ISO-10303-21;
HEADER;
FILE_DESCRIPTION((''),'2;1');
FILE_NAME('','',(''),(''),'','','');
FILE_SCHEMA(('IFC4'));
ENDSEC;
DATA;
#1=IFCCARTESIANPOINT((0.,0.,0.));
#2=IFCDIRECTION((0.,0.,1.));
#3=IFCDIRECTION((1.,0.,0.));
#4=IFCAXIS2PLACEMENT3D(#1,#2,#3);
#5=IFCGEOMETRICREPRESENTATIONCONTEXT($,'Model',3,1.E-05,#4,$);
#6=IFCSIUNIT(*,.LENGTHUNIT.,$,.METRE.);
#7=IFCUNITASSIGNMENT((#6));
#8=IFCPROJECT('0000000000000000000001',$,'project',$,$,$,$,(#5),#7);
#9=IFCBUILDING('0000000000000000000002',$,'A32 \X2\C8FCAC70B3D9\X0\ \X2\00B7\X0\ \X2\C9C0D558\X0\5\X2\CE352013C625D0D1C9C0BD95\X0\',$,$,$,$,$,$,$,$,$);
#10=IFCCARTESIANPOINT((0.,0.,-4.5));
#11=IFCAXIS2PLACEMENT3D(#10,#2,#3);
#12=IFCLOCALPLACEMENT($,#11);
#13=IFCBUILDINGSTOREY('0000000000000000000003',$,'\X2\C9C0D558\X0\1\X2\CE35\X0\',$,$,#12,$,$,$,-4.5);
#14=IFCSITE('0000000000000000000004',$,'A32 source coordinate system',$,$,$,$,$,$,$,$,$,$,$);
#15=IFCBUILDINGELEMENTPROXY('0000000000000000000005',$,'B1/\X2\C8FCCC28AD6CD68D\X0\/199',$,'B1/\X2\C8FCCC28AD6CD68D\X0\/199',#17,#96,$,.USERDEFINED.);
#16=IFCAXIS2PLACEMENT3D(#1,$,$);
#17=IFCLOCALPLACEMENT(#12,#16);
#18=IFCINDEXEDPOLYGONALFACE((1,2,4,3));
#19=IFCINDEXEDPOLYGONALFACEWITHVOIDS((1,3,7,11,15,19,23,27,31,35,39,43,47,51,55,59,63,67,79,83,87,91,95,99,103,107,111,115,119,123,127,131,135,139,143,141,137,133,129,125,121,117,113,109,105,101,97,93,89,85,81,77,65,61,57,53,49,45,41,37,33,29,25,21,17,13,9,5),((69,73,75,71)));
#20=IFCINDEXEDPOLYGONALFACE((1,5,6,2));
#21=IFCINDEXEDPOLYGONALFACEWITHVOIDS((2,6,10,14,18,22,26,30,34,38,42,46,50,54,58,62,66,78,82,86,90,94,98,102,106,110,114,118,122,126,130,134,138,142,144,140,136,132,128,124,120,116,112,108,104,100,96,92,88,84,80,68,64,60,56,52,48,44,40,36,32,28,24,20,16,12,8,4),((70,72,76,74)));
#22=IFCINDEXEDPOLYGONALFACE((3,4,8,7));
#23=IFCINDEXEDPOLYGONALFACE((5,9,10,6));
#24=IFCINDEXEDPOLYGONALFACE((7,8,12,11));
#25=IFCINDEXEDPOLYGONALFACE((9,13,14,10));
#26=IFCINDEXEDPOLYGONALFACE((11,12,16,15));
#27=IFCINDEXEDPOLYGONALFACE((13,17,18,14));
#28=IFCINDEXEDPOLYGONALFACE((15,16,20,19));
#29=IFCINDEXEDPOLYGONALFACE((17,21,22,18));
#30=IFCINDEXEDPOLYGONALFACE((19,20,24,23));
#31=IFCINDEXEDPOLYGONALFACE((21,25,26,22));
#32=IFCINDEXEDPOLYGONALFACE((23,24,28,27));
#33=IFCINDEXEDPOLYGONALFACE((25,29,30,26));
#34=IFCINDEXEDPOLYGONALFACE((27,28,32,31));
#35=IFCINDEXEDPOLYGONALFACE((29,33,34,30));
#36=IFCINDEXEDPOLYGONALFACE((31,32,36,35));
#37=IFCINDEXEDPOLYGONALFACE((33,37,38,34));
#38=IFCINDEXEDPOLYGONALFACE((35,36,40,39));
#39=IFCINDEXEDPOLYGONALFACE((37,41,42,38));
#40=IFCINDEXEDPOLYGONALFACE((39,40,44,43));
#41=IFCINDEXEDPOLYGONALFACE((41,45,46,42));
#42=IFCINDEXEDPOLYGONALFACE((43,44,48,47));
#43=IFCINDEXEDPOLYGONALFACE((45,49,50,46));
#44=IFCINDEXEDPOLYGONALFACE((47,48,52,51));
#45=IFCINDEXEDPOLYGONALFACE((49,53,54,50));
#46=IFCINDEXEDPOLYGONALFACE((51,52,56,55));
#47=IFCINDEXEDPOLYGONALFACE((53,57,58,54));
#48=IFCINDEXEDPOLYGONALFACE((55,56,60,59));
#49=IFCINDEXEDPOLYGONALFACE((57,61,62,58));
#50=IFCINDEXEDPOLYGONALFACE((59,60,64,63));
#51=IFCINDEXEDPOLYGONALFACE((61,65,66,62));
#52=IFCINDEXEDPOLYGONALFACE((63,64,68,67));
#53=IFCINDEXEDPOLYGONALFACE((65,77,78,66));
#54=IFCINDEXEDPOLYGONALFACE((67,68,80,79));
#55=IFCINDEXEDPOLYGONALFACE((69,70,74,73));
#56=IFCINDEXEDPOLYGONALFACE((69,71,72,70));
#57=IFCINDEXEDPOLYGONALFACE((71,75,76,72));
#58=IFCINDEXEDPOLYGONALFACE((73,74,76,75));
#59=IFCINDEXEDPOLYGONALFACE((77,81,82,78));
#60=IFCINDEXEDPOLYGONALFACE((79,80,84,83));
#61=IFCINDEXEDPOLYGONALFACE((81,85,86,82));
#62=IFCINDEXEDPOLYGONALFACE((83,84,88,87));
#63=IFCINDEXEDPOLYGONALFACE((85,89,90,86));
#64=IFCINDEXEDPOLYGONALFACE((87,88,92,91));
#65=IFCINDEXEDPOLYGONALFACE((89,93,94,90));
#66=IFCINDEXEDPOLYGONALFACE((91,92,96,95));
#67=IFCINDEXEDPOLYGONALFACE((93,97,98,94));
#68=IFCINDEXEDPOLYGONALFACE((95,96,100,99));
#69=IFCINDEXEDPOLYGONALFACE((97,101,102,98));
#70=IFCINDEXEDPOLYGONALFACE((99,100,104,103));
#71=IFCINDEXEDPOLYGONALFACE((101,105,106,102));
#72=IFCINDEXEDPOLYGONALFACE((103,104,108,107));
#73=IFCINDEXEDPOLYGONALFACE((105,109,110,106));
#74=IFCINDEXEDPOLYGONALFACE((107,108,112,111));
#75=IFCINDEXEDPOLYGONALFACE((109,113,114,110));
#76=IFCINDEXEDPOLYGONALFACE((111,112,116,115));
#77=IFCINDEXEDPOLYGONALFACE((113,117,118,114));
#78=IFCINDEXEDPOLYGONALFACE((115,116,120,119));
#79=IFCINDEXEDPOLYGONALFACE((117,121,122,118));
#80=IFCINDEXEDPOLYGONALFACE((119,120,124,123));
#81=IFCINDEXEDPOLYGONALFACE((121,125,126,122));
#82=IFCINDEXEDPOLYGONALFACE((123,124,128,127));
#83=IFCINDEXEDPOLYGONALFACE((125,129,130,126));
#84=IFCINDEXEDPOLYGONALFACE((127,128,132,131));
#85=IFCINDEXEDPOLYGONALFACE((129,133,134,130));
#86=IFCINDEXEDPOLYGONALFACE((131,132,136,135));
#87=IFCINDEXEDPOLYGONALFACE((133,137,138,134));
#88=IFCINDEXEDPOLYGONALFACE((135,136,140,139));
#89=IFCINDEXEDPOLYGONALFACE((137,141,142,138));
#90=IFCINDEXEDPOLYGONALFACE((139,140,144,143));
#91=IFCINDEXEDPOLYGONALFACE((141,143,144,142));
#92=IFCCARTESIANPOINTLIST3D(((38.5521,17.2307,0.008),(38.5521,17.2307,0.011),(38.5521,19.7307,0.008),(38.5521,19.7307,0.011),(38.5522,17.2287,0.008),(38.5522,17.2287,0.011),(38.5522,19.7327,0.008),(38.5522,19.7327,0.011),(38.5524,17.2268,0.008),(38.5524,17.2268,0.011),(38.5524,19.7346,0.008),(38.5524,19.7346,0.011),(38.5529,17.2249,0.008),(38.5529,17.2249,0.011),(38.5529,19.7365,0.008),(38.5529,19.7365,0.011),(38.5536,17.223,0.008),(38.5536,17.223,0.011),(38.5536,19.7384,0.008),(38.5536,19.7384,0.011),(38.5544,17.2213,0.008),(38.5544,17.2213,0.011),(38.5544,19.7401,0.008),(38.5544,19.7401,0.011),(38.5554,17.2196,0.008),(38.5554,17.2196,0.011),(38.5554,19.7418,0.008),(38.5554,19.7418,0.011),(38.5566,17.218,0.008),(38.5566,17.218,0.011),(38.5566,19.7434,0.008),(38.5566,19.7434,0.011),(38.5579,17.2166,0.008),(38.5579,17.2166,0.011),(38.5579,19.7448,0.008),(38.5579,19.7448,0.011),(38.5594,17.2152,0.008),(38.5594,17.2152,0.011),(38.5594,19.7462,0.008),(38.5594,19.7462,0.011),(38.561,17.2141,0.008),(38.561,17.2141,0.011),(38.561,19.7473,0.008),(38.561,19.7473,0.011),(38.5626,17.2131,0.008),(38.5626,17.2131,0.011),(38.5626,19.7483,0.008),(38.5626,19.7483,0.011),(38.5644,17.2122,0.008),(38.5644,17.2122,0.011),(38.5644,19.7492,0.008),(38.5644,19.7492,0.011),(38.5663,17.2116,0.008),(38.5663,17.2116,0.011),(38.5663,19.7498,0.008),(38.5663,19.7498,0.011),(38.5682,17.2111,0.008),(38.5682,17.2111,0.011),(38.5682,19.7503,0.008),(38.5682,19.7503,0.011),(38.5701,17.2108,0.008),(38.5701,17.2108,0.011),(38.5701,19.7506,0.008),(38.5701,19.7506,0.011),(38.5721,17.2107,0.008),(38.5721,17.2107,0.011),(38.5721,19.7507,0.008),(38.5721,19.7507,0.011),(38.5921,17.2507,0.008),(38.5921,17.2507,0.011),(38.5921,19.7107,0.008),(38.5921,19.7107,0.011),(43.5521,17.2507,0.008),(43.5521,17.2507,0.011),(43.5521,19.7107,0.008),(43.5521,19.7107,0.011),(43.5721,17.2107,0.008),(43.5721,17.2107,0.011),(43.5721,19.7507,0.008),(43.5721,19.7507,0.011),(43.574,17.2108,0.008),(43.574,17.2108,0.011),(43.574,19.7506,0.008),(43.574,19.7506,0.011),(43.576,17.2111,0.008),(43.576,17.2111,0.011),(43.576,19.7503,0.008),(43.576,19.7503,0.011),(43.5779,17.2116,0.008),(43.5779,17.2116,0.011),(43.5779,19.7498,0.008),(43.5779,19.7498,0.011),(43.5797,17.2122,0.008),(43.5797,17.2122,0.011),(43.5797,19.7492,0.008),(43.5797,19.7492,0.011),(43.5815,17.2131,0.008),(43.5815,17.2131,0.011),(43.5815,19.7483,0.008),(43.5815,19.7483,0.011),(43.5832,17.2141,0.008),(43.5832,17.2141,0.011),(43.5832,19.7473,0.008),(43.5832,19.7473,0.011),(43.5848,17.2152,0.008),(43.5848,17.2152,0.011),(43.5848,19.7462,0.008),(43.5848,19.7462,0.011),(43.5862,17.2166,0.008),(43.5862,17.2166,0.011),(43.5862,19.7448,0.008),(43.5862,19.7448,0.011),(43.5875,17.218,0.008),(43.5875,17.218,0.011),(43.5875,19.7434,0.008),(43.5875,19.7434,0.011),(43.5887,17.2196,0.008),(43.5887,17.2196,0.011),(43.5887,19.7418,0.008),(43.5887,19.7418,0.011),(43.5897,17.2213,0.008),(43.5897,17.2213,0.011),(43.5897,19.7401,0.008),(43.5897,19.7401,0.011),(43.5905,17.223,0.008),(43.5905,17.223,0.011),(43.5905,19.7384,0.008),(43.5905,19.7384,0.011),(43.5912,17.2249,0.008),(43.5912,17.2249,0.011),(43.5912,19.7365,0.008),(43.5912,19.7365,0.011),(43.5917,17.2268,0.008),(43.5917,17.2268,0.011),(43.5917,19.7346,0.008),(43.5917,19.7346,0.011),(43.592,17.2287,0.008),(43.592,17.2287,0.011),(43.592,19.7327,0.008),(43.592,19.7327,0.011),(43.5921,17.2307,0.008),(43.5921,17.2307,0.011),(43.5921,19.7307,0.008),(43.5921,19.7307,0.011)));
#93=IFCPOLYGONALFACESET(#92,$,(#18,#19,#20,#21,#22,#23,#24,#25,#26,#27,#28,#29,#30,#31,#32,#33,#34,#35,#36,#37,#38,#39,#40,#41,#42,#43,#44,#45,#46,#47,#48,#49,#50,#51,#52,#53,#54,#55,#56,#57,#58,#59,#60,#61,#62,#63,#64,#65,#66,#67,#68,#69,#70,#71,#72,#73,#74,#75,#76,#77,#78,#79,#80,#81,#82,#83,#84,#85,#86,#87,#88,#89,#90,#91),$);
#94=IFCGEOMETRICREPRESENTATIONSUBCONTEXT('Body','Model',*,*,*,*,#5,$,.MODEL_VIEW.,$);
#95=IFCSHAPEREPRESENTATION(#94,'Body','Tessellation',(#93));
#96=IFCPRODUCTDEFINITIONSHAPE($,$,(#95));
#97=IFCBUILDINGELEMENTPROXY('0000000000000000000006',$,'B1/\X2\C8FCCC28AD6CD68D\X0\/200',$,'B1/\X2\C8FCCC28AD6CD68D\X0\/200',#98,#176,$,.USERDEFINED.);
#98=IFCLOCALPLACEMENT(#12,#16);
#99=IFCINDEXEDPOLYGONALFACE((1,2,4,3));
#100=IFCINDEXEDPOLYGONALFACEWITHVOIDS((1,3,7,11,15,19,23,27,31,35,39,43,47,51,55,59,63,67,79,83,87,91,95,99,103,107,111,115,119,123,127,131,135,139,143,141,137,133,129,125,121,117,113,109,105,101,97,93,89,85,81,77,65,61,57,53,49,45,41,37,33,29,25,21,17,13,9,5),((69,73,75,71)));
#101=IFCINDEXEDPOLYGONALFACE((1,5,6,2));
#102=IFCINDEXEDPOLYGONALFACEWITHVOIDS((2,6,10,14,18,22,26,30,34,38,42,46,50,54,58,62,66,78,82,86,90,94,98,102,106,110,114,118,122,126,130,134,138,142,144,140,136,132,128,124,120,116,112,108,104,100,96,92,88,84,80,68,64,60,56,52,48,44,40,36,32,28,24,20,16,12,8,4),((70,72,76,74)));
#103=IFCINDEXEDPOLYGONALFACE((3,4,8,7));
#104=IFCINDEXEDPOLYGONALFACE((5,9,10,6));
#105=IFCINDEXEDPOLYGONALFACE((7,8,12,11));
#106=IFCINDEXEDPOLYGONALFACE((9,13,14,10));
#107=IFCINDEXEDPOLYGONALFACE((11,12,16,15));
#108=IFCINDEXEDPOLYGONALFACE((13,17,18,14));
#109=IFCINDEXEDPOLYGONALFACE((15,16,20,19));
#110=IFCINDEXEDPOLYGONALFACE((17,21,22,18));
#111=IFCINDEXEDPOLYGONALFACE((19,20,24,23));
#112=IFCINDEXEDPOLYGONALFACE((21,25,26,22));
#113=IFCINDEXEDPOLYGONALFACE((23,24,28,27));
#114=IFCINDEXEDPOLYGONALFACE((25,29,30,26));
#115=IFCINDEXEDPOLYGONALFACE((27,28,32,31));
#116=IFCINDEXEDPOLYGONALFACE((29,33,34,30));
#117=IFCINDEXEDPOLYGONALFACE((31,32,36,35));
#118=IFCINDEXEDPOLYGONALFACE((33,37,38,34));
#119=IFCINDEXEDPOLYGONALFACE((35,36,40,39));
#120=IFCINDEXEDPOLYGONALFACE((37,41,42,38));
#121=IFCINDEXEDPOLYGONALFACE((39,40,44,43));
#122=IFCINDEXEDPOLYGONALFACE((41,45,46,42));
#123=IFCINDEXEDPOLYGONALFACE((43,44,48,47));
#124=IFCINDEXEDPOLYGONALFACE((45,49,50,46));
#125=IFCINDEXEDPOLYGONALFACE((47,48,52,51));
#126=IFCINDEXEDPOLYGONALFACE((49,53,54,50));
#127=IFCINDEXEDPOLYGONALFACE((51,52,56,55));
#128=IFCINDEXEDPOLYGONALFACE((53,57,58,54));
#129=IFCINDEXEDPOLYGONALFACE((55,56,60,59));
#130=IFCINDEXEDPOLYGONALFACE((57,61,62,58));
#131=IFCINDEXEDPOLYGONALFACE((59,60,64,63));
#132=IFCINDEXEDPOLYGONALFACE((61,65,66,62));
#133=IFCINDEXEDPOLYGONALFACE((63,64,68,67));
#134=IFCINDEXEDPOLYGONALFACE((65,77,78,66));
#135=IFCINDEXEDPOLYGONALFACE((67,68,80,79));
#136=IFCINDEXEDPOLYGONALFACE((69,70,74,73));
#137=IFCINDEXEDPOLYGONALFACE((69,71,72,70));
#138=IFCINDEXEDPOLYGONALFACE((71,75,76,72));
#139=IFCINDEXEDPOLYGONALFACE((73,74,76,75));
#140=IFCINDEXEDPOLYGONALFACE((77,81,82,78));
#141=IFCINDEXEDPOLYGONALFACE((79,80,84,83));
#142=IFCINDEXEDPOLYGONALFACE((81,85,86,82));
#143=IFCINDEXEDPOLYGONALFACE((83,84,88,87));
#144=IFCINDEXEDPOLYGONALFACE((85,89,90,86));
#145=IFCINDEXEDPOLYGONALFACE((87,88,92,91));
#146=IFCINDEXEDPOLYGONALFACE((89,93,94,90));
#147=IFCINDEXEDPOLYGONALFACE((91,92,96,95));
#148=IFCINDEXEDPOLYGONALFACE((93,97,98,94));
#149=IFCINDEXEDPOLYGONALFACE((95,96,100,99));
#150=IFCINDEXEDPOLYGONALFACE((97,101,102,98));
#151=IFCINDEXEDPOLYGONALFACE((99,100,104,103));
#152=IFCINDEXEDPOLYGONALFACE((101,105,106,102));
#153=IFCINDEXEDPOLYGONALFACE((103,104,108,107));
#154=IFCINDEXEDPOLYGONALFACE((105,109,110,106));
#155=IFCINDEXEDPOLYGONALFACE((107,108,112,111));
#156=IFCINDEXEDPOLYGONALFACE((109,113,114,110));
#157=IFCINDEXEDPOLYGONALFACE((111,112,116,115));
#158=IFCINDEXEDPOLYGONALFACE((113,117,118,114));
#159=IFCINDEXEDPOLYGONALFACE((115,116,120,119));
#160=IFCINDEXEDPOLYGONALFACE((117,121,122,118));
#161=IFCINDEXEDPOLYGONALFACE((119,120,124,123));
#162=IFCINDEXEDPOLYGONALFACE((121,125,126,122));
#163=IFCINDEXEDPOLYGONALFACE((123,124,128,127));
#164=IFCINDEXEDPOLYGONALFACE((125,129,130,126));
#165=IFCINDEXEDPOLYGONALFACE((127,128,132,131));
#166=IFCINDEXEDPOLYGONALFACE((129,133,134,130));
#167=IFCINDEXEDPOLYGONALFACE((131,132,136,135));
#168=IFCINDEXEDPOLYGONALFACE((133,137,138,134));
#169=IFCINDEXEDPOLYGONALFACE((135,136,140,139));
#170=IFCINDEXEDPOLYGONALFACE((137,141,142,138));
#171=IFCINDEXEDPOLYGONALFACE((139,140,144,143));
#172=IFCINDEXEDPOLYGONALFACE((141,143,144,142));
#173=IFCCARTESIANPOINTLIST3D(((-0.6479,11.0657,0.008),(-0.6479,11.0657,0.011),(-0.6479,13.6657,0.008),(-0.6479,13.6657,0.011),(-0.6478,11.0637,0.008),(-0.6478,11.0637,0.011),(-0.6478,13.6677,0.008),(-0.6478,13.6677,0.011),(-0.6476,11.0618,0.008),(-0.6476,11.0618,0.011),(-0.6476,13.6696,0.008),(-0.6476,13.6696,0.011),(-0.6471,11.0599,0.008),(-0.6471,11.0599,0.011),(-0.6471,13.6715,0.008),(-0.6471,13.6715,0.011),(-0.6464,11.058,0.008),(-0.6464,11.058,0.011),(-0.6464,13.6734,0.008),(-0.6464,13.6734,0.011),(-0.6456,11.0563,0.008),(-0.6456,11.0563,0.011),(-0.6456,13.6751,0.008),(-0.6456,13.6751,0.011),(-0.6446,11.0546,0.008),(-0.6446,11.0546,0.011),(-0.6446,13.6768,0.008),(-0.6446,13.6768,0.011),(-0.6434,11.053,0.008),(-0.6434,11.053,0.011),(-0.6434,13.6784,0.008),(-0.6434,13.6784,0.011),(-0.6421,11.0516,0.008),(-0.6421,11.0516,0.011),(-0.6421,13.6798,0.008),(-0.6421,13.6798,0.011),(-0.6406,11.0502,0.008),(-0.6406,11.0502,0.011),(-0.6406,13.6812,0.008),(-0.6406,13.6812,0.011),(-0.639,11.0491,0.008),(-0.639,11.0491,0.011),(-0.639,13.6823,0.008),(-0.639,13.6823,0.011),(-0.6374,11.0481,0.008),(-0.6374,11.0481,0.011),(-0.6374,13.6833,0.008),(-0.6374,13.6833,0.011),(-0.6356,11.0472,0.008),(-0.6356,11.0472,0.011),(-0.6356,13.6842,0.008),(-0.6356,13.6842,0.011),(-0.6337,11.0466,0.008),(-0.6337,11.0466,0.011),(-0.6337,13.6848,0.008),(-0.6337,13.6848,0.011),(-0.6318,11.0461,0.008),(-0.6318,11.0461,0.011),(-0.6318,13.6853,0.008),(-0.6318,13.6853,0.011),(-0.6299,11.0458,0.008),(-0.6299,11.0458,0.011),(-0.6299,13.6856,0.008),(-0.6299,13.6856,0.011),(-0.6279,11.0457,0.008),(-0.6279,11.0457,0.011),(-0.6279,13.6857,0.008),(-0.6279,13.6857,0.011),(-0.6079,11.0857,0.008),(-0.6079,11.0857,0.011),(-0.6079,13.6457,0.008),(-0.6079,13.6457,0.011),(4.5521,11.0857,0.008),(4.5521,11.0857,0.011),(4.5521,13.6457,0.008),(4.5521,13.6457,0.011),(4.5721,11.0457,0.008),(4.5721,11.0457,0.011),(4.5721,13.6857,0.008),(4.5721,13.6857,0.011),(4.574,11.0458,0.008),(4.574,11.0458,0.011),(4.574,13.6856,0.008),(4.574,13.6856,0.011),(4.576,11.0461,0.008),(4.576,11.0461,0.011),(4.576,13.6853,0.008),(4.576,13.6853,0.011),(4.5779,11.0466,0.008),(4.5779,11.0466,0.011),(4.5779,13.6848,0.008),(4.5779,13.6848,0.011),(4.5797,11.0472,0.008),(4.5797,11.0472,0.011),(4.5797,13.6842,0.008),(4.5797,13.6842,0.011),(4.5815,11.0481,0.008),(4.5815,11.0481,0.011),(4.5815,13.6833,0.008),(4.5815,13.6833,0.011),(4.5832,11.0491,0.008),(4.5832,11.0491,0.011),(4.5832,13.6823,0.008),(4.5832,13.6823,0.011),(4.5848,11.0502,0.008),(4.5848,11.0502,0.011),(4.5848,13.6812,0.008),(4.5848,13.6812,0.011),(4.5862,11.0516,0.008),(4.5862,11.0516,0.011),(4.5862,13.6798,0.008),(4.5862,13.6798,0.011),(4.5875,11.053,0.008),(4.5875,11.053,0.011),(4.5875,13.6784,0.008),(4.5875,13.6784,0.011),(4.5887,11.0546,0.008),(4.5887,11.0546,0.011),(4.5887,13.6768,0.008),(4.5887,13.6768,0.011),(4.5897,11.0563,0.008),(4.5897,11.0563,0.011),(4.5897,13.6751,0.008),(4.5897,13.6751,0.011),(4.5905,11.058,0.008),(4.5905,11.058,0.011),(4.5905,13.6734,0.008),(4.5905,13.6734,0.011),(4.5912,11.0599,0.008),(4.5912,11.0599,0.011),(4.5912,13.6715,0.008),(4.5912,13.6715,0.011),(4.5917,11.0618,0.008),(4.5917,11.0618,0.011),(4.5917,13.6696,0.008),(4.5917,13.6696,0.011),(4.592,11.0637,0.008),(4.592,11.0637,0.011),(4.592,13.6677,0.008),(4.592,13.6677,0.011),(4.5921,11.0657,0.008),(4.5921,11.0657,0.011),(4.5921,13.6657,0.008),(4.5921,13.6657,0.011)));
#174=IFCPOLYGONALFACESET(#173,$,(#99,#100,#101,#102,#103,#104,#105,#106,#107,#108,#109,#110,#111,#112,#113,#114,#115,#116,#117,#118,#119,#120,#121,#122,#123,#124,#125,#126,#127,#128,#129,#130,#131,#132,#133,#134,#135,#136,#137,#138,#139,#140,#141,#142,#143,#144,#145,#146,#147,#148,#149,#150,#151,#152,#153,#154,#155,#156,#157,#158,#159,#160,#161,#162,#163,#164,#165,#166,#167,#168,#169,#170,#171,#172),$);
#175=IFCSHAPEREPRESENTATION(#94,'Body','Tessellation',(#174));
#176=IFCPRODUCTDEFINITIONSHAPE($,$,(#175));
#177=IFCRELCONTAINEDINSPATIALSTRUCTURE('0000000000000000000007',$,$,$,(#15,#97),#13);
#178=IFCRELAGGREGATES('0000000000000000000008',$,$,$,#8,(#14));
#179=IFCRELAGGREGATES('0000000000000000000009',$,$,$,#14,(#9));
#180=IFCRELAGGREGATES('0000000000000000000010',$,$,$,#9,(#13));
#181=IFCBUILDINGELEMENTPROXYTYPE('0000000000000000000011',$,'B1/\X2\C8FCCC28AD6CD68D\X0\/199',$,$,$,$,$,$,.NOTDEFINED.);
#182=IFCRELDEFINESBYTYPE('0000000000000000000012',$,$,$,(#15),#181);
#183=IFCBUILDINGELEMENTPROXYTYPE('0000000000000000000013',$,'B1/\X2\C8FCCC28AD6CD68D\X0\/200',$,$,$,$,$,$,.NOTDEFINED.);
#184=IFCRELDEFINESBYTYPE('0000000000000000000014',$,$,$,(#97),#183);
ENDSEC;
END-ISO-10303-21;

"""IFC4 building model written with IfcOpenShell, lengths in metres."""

from ifc_helpers import new_model, si_unit, frame, origin, origin_with_axes, place, context, subcontext, project, spatial, polyline, outline, extrude, source, transform, mapped, type_object, type_shapes, element, save


model = new_model("IFC4")

# Units and contexts
model_context = context("Model", 3, precision=1e-05, world=origin_with_axes())
body_context = subcontext(model_context, "Body", "Model", "MODEL_VIEW")
ifc_project = project(units=[si_unit("LENGTHUNIT", "METRE")], contexts=[model_context])

# Site, building, storey
site = spatial("IfcSite", under=ifc_project, Name="A32 source coordinate system")
building = spatial("IfcBuilding", under=site, Name="A32 주거동 · 지하5층–옥탑지붕")
storey_placement = place(None, frame((0.0, 0.0, -4.5), z_axis=(0.0, 0.0, 1.0), x_axis=(1.0, 0.0, 0.0)))
storey = spatial("IfcBuildingStorey", under=building, at=storey_placement, Name="지하1층", Elevation=-4.5)

# Building element proxies
building_element_proxy_type_1 = type_object("IfcBuildingElementProxyType", Name="B1/주차구획/199", PredefinedType="NOTDEFINED")
shared_shape_1 = source(origin(), body_context, "Body", "SweptSolid", [
    extrude(outline(polyline([(43.5721, 19.7507), (43.574, 19.7506), (43.576, 19.7503), (43.5779, 19.7498), (43.5797, 19.7492), (43.5815, 19.7483), (43.5832, 19.7473), (43.5848, 19.7462), (43.5862, 19.7448), (43.5875, 19.7434), (43.5887, 19.7418), (43.5897, 19.7401), (43.5905, 19.7384), (43.5912, 19.7365), (43.5917, 19.7346), (43.592, 19.7327), (43.5921, 19.7307), (43.5921, 17.2307), (43.592, 17.2287), (43.5917, 17.2268), (43.5912, 17.2249), (43.5905, 17.223), (43.5897, 17.2213), (43.5887, 17.2196), (43.5875, 17.218), (43.5862, 17.2166), (43.5848, 17.2152), (43.5832, 17.2141), (43.5815, 17.2131), (43.5797, 17.2122), (43.5779, 17.2116), (43.576, 17.2111), (43.574, 17.2108), (43.5721, 17.2107), (38.5721, 17.2107), (38.5701, 17.2108), (38.5682, 17.2111), (38.5663, 17.2116), (38.5644, 17.2122), (38.5626, 17.2131), (38.561, 17.2141), (38.5594, 17.2152), (38.5579, 17.2166), (38.5566, 17.218), (38.5554, 17.2196), (38.5544, 17.2213), (38.5536, 17.223), (38.5529, 17.2249), (38.5524, 17.2268), (38.5522, 17.2287), (38.5521, 17.2307), (38.5521, 19.7307), (38.5522, 19.7327), (38.5524, 19.7346), (38.5529, 19.7365), (38.5536, 19.7384), (38.5544, 19.7401), (38.5554, 19.7418), (38.5566, 19.7434), (38.5579, 19.7448), (38.5594, 19.7462), (38.561, 19.7473), (38.5626, 19.7483), (38.5644, 19.7492), (38.5663, 19.7498), (38.5682, 19.7503), (38.5701, 19.7506), (38.5721, 19.7507), (43.5721, 19.7507)]), holes=[polyline([(43.5521, 19.7107), (38.5921, 19.7107), (38.5921, 17.2507), (43.5521, 17.2507), (43.5521, 19.7107)])]), frame((0.0, 0.0, 0.008)), (0.0, 0.0, 1.0), 0.003),
])
type_shapes(building_element_proxy_type_1, [shared_shape_1])
proxy_1_placement = place(storey_placement, origin_with_axes())
element("IfcBuildingElementProxy", 1, at=proxy_1_placement, inside=storey, type_object=building_element_proxy_type_1, Name="B1/주차구획/199", ObjectType="B1/주차구획/199", PredefinedType="USERDEFINED", context=body_context, shape_type="MappedRepresentation", body=[
    mapped(shared_shape_1, transform((0.0, 0.0, 0.0), scale=1.0)),
])
building_element_proxy_type_2 = type_object("IfcBuildingElementProxyType", Name="B1/주차구획/200", PredefinedType="NOTDEFINED")
shared_shape_2 = source(origin(), body_context, "Body", "SweptSolid", [
    extrude(outline(polyline([(-0.6279, 11.0457), (-0.6299, 11.0458), (-0.6318, 11.0461), (-0.6337, 11.0466), (-0.6356, 11.0472), (-0.6374, 11.0481), (-0.639, 11.0491), (-0.6406, 11.0502), (-0.6421, 11.0516), (-0.6434, 11.053), (-0.6446, 11.0546), (-0.6456, 11.0563), (-0.6464, 11.058), (-0.6471, 11.0599), (-0.6476, 11.0618), (-0.6478, 11.0637), (-0.6479, 11.0657), (-0.6479, 13.6657), (-0.6478, 13.6677), (-0.6476, 13.6696), (-0.6471, 13.6715), (-0.6464, 13.6734), (-0.6456, 13.6751), (-0.6446, 13.6768), (-0.6434, 13.6784), (-0.6421, 13.6798), (-0.6406, 13.6812), (-0.639, 13.6823), (-0.6374, 13.6833), (-0.6356, 13.6842), (-0.6337, 13.6848), (-0.6318, 13.6853), (-0.6299, 13.6856), (-0.6279, 13.6857), (4.5721, 13.6857), (4.574, 13.6856), (4.576, 13.6853), (4.5779, 13.6848), (4.5797, 13.6842), (4.5815, 13.6833), (4.5832, 13.6823), (4.5848, 13.6812), (4.5862, 13.6798), (4.5875, 13.6784), (4.5887, 13.6768), (4.5897, 13.6751), (4.5905, 13.6734), (4.5912, 13.6715), (4.5917, 13.6696), (4.592, 13.6677), (4.5921, 13.6657), (4.5921, 11.0657), (4.592, 11.0637), (4.5917, 11.0618), (4.5912, 11.0599), (4.5905, 11.058), (4.5897, 11.0563), (4.5887, 11.0546), (4.5875, 11.053), (4.5862, 11.0516), (4.5848, 11.0502), (4.5832, 11.0491), (4.5815, 11.0481), (4.5797, 11.0472), (4.5779, 11.0466), (4.576, 11.0461), (4.574, 11.0458), (4.5721, 11.0457), (-0.6279, 11.0457)]), holes=[polyline([(-0.6079, 11.0857), (4.5521, 11.0857), (4.5521, 13.6457), (-0.6079, 13.6457), (-0.6079, 11.0857)])]), frame((0.0, 0.0, 0.008)), (0.0, 0.0, 1.0), 0.003),
])
type_shapes(building_element_proxy_type_2, [shared_shape_2])
proxy_2_placement = place(storey_placement, origin_with_axes())
element("IfcBuildingElementProxy", 2, at=proxy_2_placement, inside=storey, type_object=building_element_proxy_type_2, Name="B1/주차구획/200", ObjectType="B1/주차구획/200", PredefinedType="USERDEFINED", context=body_context, shape_type="MappedRepresentation", body=[
    mapped(shared_shape_2, transform((0.0, 0.0, 0.0), scale=1.0)),
])

save(model, "model.ifc")
